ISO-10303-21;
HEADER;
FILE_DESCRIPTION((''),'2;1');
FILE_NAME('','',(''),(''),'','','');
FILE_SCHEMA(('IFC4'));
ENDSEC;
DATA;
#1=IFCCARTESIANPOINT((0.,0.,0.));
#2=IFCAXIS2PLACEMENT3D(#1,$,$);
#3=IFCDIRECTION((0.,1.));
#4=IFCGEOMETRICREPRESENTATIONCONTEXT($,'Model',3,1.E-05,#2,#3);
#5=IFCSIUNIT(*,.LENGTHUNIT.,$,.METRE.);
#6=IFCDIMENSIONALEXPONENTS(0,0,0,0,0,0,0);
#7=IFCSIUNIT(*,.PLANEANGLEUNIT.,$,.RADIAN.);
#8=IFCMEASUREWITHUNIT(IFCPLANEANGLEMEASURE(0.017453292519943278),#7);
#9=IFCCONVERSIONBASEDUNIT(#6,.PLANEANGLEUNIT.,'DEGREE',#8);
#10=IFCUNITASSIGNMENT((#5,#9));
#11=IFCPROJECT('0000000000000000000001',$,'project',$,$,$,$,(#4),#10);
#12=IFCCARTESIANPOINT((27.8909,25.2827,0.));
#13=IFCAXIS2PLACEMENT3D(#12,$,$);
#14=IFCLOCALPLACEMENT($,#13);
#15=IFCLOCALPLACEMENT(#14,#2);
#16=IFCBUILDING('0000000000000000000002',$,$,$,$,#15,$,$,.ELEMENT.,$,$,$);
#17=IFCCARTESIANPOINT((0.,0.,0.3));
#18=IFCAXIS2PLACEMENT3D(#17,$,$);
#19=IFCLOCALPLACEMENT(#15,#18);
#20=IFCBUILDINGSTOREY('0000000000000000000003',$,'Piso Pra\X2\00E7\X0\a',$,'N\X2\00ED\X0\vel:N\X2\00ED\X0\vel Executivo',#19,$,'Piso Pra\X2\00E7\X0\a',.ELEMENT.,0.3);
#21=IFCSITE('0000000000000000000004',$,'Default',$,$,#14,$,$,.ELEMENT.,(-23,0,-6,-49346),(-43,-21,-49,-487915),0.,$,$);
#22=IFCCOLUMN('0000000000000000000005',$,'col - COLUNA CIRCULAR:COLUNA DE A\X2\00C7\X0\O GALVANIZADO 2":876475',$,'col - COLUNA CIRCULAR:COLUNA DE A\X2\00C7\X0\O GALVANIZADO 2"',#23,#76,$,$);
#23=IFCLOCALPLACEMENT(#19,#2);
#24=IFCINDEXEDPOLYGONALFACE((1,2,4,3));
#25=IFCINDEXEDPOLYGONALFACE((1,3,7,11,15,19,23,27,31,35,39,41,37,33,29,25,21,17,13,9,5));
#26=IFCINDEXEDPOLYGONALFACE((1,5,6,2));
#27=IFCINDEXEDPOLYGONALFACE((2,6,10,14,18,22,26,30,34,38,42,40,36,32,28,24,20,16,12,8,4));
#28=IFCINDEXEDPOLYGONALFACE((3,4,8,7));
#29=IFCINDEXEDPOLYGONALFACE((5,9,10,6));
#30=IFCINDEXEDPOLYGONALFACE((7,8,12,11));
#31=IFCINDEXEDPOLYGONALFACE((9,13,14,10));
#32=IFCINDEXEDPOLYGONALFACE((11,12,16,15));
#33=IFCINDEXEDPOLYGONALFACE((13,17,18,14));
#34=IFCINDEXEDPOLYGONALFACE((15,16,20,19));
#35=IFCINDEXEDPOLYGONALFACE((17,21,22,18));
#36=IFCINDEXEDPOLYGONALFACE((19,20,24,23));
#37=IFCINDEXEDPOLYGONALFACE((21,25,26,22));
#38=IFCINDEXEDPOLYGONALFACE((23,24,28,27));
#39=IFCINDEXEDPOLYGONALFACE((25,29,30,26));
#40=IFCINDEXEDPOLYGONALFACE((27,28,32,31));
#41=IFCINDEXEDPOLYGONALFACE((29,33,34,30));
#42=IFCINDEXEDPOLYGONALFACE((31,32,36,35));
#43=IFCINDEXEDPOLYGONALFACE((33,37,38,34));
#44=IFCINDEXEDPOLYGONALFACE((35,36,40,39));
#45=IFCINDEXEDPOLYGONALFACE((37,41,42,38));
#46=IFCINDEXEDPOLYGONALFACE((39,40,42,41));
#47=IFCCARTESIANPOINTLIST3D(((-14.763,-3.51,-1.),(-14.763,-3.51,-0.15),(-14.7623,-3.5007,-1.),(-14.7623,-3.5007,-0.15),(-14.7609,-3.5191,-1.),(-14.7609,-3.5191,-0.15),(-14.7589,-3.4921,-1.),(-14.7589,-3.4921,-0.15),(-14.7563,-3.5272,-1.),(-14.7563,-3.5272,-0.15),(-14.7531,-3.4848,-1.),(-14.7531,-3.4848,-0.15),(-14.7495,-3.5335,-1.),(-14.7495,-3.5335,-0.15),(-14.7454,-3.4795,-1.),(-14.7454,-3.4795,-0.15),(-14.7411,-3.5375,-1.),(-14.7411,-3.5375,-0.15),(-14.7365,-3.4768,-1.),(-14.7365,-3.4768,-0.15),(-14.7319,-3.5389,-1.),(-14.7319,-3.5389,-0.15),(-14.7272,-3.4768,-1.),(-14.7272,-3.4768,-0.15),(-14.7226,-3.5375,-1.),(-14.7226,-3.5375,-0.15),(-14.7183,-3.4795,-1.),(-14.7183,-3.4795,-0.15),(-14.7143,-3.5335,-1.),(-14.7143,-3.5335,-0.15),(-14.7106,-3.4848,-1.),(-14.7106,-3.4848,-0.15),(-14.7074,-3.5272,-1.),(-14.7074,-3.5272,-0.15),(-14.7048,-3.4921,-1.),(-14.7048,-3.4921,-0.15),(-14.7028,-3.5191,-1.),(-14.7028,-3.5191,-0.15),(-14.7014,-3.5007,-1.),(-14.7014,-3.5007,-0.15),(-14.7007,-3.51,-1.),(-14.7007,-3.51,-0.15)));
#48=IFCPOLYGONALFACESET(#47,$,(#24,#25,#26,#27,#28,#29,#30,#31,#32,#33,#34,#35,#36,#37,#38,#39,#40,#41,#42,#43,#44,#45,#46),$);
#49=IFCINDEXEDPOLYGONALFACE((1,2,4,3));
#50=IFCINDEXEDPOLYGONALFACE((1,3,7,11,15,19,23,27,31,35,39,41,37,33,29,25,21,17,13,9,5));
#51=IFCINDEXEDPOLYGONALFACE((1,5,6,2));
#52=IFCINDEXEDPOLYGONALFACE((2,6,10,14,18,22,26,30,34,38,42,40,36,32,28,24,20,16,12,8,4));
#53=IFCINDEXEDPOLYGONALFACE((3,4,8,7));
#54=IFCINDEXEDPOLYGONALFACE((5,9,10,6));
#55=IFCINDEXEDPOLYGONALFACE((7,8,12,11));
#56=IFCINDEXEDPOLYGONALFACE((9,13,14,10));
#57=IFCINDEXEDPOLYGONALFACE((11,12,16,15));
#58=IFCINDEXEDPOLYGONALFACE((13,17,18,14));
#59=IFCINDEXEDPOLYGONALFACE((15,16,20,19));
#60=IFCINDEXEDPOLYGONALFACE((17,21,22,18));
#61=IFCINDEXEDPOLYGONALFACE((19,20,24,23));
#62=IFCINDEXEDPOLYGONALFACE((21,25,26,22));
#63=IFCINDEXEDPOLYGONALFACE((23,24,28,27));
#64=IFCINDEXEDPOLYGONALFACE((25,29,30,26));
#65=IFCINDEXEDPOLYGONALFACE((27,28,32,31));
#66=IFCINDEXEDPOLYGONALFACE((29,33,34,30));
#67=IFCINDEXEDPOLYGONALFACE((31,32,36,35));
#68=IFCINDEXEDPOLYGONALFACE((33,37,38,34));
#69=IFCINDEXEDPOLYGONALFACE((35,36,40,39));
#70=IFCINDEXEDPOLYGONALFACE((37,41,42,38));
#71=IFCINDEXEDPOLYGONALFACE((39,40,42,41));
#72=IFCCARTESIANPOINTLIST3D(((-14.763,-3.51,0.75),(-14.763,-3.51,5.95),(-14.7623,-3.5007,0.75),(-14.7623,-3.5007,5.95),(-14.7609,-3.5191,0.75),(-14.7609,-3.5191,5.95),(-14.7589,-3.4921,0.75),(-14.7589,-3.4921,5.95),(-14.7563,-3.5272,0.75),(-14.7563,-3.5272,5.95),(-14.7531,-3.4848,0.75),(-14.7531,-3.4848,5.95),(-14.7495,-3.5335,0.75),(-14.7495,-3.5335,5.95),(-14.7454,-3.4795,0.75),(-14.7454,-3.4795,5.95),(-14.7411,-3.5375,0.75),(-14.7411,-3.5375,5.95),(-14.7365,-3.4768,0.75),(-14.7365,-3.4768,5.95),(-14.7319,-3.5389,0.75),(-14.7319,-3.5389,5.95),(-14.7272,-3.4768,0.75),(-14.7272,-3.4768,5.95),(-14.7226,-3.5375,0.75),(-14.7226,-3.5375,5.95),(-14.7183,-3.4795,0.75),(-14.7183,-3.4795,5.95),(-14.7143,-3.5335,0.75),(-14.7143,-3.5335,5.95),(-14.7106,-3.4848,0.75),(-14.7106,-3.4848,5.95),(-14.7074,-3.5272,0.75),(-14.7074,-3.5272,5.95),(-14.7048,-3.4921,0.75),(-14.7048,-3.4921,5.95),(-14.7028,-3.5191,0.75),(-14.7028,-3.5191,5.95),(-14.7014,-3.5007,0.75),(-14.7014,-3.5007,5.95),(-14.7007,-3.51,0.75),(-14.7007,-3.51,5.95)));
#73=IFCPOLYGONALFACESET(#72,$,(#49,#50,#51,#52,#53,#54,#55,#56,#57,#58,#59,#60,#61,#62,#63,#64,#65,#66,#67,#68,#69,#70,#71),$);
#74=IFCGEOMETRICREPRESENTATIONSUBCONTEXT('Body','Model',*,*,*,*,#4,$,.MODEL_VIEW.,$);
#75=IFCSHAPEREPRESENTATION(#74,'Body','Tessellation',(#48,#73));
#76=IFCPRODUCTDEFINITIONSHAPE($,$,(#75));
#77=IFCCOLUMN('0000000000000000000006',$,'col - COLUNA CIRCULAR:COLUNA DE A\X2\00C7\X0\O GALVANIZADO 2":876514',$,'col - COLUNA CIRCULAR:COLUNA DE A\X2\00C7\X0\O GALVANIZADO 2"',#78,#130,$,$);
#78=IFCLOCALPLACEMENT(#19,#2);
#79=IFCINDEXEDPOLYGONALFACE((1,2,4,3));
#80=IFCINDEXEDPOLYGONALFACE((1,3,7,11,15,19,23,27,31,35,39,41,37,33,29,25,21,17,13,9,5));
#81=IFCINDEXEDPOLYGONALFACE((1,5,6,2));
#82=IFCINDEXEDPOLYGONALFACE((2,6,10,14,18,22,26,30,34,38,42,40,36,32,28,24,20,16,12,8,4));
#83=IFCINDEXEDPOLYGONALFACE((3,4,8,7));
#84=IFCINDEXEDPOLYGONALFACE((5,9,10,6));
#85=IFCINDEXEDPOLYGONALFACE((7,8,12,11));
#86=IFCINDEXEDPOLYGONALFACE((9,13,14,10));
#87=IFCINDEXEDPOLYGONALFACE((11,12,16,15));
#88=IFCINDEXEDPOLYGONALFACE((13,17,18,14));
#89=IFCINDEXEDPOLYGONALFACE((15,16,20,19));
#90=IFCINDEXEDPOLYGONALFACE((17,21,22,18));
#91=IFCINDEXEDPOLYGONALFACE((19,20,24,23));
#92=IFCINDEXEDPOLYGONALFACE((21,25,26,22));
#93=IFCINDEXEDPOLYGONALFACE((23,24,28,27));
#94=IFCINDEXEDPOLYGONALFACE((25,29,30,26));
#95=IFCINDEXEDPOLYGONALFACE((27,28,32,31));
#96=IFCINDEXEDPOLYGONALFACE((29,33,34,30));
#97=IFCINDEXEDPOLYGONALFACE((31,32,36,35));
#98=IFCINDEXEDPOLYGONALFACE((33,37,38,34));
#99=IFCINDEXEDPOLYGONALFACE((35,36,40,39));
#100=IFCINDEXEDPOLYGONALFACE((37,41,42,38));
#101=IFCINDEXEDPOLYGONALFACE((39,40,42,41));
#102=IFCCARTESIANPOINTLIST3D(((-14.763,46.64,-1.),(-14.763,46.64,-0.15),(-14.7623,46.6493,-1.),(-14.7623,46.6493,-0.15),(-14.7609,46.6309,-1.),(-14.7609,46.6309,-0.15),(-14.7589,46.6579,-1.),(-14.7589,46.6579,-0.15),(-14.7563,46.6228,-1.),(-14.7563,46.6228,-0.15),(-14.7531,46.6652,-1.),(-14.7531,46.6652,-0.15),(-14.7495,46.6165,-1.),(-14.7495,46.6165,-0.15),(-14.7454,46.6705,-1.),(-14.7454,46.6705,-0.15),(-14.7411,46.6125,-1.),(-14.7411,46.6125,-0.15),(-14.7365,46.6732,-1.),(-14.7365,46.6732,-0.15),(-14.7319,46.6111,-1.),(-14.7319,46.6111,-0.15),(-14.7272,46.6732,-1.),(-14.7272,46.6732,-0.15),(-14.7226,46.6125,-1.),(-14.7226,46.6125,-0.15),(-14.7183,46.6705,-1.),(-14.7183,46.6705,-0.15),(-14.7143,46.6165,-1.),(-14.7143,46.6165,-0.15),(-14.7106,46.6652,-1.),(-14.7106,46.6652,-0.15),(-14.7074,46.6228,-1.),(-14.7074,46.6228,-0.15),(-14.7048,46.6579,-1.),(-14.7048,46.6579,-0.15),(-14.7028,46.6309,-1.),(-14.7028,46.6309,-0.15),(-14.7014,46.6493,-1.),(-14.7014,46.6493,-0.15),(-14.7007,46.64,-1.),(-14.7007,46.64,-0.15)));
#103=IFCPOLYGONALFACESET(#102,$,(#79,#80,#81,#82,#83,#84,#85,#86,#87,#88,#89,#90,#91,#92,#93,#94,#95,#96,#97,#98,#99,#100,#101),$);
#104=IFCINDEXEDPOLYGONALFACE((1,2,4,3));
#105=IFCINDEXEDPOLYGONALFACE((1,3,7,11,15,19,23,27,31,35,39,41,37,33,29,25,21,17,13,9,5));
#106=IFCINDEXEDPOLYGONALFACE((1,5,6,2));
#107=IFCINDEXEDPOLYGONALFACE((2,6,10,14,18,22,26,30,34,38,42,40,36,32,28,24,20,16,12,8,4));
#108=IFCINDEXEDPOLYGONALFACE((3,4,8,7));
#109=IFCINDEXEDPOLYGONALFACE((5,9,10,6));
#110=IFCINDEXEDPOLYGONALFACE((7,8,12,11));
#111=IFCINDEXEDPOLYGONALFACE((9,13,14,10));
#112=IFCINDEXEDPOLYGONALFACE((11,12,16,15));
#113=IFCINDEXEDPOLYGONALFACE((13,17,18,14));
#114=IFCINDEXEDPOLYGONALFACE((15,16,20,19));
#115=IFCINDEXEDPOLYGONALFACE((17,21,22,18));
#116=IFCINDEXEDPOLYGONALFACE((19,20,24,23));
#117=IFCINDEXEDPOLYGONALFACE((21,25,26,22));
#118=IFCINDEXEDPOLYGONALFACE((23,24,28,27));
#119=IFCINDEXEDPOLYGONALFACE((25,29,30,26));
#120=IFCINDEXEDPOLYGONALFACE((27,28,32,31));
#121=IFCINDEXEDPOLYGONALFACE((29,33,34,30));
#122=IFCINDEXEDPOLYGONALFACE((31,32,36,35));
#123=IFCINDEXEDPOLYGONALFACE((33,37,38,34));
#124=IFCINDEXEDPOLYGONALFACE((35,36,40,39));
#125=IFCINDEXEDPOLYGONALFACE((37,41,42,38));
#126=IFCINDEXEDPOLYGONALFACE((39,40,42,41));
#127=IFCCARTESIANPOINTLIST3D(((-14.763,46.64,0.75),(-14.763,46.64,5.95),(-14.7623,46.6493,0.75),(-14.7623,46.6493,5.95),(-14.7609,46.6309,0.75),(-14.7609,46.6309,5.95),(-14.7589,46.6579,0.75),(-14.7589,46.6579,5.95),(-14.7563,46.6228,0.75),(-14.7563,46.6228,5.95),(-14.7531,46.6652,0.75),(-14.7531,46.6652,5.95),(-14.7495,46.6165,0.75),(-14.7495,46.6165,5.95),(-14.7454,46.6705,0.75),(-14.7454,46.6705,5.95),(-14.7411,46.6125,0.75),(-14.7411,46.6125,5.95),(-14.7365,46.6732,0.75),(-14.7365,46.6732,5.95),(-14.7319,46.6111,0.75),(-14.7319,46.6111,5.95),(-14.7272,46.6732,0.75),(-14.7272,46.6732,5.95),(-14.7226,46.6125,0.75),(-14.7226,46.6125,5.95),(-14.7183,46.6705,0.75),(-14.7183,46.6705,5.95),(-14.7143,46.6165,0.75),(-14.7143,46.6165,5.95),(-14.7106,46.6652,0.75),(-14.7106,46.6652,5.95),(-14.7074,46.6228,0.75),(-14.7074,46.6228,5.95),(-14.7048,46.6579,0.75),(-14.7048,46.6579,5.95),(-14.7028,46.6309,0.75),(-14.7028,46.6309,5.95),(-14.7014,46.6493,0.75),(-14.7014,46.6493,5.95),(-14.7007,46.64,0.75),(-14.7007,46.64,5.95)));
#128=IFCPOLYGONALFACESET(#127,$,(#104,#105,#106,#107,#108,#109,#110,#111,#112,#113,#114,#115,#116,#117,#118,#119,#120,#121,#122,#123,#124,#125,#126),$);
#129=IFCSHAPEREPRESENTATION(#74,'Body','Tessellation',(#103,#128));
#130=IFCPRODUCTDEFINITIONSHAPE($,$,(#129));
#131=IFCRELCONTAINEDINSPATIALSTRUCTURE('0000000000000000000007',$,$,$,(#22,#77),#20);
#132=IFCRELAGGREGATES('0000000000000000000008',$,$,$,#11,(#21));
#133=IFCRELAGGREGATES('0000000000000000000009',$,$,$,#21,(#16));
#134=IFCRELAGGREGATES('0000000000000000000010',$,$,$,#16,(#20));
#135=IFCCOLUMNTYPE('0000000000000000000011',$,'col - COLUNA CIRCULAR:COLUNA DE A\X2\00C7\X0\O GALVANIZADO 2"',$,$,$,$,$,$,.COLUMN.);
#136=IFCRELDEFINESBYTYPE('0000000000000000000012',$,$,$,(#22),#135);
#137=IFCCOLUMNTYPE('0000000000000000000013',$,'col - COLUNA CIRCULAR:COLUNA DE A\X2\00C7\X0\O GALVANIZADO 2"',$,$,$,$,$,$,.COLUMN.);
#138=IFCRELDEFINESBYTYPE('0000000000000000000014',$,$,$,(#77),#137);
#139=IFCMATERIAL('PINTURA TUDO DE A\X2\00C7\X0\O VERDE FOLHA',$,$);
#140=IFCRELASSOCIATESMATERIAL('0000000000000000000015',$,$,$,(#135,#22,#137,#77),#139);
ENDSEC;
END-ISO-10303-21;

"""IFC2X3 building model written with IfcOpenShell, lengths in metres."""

from ifc_helpers import new_model, entity, si_unit, converted_unit, direction, frame, origin, origin_2d_with_axis, place, context, subcontext, project, spatial, circle, extrude, source, transform, mapped, material, type_object, type_shapes, element, save


model = new_model("IFC2X3")

# Units and contexts
model_context = context("Model", 3, precision=1e-05, world=origin(), true_north=direction((0.0, 1.0)))
body_context = subcontext(model_context, "Body", "Model", "MODEL_VIEW")
ifc_project = project(units=[si_unit("LENGTHUNIT", "METRE"), converted_unit("PLANEANGLEUNIT", "DEGREE", entity("IfcPlaneAngleMeasure", 0.017453292519943278), si_unit("PLANEANGLEUNIT", "RADIAN"), dimensions=[0, 0, 0, 0, 0, 0, 0])], contexts=[model_context])

# Site, building, storey
site_placement = place(None, frame((27.8909, 25.2827, 0.0)))
site = spatial("IfcSite", under=ifc_project, at=site_placement, Name="Default", CompositionType="ELEMENT", RefLatitude=(-23, 0, -6, -49346), RefLongitude=(-43, -21, -49, -487915), RefElevation=0.0)
building_placement = place(site_placement, origin())
building = spatial("IfcBuilding", under=site, at=building_placement, CompositionType="ELEMENT")
storey_placement = place(building_placement, frame((0.0, 0.0, 0.3)))
storey = spatial("IfcBuildingStorey", under=building, at=storey_placement, Name="Piso Praça", ObjectType="Nível:Nível Executivo", LongName="Piso Praça", CompositionType="ELEMENT", Elevation=0.3)

# Columns
ifc_material = material(Name="PINTURA TUDO DE AÇO VERDE FOLHA")
column_type_1 = type_object("IfcColumnType", Name="col - COLUNA CIRCULAR:COLUNA DE AÇO GALVANIZADO 2\"", PredefinedType="COLUMN", material=ifc_material)
shared_shape_1 = source(origin(), body_context, "Body", "SweptSolid", [
    extrude(circle(Radius=0.0312, at=origin_2d_with_axis()), frame((-14.7319, -3.5077, -0.7), z_axis=(0.0, 0.0, 1.0), x_axis=(0.0, -1.0, 0.0)), (0.0, 0.0, 1.0), 0.85),
    extrude(circle(Radius=0.0312, at=origin_2d_with_axis()), frame((-14.7319, -3.5077, 1.05), z_axis=(0.0, 0.0, 1.0), x_axis=(0.0, -1.0, 0.0)), (0.0, 0.0, 1.0), 5.2),
])
type_shapes(column_type_1, [shared_shape_1])
column_1_placement = place(storey_placement, frame((0.0, 0.0, -0.3)))
element("IfcColumn", 1, at=column_1_placement, inside=storey, type_object=column_type_1, material=ifc_material, Name="col - COLUNA CIRCULAR:COLUNA DE AÇO GALVANIZADO 2\":876475", ObjectType="col - COLUNA CIRCULAR:COLUNA DE AÇO GALVANIZADO 2\"", context=body_context, shape_type="MappedRepresentation", body=[
    mapped(shared_shape_1, transform((0.0, 0.0, 0.0), scale=1.0)),
])
column_type_2 = type_object("IfcColumnType", Name="col - COLUNA CIRCULAR:COLUNA DE AÇO GALVANIZADO 2\"", PredefinedType="COLUMN", material=ifc_material)
shared_shape_2 = source(origin(), body_context, "Body", "SweptSolid", [
    extrude(circle(Radius=0.0312, at=origin_2d_with_axis()), frame((-14.7319, 46.6423, -0.7), z_axis=(0.0, 0.0, 1.0), x_axis=(0.0, -1.0, 0.0)), (0.0, 0.0, 1.0), 0.85),
    extrude(circle(Radius=0.0312, at=origin_2d_with_axis()), frame((-14.7319, 46.6423, 1.05), z_axis=(0.0, 0.0, 1.0), x_axis=(0.0, -1.0, 0.0)), (0.0, 0.0, 1.0), 5.2),
])
type_shapes(column_type_2, [shared_shape_2])
column_2_placement = place(storey_placement, frame((0.0, 0.0, -0.3)))
element("IfcColumn", 2, at=column_2_placement, inside=storey, type_object=column_type_2, material=ifc_material, Name="col - COLUNA CIRCULAR:COLUNA DE AÇO GALVANIZADO 2\":876514", ObjectType="col - COLUNA CIRCULAR:COLUNA DE AÇO GALVANIZADO 2\"", context=body_context, shape_type="MappedRepresentation", body=[
    mapped(shared_shape_2, transform((0.0, 0.0, 0.0), scale=1.0)),
])

save(model, "model.ifc")
